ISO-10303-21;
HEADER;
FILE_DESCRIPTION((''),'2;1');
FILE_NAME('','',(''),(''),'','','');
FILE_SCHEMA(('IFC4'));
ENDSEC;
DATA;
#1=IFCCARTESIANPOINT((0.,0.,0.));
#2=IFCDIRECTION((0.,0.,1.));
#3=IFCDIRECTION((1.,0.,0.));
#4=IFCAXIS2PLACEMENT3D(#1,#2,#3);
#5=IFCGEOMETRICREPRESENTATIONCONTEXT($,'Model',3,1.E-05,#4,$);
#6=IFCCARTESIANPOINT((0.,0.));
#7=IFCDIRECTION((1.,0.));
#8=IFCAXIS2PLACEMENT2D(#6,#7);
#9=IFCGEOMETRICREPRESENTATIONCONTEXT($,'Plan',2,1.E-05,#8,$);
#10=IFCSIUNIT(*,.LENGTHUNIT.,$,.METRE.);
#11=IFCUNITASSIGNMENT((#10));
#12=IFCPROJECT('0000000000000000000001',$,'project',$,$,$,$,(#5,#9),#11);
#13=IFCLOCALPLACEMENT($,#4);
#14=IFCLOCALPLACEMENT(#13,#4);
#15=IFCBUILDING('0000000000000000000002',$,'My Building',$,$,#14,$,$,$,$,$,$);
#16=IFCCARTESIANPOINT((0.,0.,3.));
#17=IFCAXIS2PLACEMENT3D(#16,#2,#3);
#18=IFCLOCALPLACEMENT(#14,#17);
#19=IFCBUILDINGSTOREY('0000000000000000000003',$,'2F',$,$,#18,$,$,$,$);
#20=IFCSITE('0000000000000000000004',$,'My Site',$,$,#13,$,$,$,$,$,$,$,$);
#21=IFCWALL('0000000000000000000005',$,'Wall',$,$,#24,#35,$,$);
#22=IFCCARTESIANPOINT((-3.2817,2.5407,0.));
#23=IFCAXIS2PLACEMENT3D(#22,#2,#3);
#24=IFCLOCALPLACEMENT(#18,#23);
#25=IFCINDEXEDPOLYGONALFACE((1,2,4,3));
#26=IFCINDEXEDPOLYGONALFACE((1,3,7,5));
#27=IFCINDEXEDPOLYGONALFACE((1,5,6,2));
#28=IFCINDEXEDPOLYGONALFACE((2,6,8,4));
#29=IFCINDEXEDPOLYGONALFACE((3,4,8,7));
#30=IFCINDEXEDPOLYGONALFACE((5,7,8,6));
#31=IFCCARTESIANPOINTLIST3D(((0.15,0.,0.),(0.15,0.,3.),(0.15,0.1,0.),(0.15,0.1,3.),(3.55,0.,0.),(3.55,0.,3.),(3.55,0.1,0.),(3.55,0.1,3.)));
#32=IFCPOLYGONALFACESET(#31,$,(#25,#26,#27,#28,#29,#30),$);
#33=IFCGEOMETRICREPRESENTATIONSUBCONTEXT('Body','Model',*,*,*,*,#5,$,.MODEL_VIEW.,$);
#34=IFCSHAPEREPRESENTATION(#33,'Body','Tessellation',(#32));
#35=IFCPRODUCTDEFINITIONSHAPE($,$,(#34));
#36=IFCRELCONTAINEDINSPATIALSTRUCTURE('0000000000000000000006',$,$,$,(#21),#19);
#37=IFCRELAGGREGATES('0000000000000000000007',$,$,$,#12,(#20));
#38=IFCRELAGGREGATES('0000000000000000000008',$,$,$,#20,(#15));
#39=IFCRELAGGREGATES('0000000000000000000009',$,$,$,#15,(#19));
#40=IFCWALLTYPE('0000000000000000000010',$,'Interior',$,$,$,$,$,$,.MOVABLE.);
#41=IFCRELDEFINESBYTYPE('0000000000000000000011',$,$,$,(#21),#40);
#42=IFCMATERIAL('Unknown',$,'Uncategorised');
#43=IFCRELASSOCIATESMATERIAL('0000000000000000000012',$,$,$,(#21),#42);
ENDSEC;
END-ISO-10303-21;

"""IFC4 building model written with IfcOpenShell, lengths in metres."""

from ifc_helpers import new_model, si_unit, frame, origin_with_axes, origin_2d_with_axis, place, context, subcontext, project, spatial, line, indexed_curve, outline, extrude, material, type_object, element, save


model = new_model("IFC4")

# Units and contexts
model_context = context("Model", 3, precision=1e-05, world=origin_with_axes())
plan_context = context("Plan", 2, precision=1e-05, world=origin_2d_with_axis())
body_context_1 = subcontext(model_context, "Body", "Model", "MODEL_VIEW")
ifc_project = project(units=[si_unit("LENGTHUNIT", "METRE")], contexts=[model_context, plan_context])

# Site, building, storey
site_placement = place(None, origin_with_axes())
site = spatial("IfcSite", under=ifc_project, at=site_placement, Name="My Site")
building_placement = place(site_placement, origin_with_axes())
building = spatial("IfcBuilding", under=site, at=building_placement, Name="My Building")
storey_placement = place(building_placement, frame((0.0, 0.0, 3.0), z_axis=(0.0, 0.0, 1.0), x_axis=(1.0, 0.0, 0.0)))
storey = spatial("IfcBuildingStorey", under=building, at=storey_placement, Name="2F")

# Shared definitions
ifc_material = material(Name="Unknown", Category="Uncategorised")

# Shared definitions
wall_type_1 = type_object("IfcWallType", Name="Interior", PredefinedType="MOVABLE")

# Wall
wall_1_placement = place(storey_placement, frame((-3.2817, 2.5407, 0.0), z_axis=(0.0, 0.0, 1.0), x_axis=(1.0, 0.0, 0.0)))
element("IfcWall", 1, at=wall_1_placement, inside=storey, type_object=wall_type_1, material=ifc_material, Name="Wall", context=body_context_1, shape_type="SweptSolid", body=[
    extrude(outline(indexed_curve([(0.15, 0.0), (0.15, 0.1), (3.55, 0.1), (3.55, 0.0)], segments=[line(1, 2, 3, 4, 1)])), origin_with_axes(), (0.0, 0.0, 1.0), 3.0),
])

save(model, "model.ifc")
